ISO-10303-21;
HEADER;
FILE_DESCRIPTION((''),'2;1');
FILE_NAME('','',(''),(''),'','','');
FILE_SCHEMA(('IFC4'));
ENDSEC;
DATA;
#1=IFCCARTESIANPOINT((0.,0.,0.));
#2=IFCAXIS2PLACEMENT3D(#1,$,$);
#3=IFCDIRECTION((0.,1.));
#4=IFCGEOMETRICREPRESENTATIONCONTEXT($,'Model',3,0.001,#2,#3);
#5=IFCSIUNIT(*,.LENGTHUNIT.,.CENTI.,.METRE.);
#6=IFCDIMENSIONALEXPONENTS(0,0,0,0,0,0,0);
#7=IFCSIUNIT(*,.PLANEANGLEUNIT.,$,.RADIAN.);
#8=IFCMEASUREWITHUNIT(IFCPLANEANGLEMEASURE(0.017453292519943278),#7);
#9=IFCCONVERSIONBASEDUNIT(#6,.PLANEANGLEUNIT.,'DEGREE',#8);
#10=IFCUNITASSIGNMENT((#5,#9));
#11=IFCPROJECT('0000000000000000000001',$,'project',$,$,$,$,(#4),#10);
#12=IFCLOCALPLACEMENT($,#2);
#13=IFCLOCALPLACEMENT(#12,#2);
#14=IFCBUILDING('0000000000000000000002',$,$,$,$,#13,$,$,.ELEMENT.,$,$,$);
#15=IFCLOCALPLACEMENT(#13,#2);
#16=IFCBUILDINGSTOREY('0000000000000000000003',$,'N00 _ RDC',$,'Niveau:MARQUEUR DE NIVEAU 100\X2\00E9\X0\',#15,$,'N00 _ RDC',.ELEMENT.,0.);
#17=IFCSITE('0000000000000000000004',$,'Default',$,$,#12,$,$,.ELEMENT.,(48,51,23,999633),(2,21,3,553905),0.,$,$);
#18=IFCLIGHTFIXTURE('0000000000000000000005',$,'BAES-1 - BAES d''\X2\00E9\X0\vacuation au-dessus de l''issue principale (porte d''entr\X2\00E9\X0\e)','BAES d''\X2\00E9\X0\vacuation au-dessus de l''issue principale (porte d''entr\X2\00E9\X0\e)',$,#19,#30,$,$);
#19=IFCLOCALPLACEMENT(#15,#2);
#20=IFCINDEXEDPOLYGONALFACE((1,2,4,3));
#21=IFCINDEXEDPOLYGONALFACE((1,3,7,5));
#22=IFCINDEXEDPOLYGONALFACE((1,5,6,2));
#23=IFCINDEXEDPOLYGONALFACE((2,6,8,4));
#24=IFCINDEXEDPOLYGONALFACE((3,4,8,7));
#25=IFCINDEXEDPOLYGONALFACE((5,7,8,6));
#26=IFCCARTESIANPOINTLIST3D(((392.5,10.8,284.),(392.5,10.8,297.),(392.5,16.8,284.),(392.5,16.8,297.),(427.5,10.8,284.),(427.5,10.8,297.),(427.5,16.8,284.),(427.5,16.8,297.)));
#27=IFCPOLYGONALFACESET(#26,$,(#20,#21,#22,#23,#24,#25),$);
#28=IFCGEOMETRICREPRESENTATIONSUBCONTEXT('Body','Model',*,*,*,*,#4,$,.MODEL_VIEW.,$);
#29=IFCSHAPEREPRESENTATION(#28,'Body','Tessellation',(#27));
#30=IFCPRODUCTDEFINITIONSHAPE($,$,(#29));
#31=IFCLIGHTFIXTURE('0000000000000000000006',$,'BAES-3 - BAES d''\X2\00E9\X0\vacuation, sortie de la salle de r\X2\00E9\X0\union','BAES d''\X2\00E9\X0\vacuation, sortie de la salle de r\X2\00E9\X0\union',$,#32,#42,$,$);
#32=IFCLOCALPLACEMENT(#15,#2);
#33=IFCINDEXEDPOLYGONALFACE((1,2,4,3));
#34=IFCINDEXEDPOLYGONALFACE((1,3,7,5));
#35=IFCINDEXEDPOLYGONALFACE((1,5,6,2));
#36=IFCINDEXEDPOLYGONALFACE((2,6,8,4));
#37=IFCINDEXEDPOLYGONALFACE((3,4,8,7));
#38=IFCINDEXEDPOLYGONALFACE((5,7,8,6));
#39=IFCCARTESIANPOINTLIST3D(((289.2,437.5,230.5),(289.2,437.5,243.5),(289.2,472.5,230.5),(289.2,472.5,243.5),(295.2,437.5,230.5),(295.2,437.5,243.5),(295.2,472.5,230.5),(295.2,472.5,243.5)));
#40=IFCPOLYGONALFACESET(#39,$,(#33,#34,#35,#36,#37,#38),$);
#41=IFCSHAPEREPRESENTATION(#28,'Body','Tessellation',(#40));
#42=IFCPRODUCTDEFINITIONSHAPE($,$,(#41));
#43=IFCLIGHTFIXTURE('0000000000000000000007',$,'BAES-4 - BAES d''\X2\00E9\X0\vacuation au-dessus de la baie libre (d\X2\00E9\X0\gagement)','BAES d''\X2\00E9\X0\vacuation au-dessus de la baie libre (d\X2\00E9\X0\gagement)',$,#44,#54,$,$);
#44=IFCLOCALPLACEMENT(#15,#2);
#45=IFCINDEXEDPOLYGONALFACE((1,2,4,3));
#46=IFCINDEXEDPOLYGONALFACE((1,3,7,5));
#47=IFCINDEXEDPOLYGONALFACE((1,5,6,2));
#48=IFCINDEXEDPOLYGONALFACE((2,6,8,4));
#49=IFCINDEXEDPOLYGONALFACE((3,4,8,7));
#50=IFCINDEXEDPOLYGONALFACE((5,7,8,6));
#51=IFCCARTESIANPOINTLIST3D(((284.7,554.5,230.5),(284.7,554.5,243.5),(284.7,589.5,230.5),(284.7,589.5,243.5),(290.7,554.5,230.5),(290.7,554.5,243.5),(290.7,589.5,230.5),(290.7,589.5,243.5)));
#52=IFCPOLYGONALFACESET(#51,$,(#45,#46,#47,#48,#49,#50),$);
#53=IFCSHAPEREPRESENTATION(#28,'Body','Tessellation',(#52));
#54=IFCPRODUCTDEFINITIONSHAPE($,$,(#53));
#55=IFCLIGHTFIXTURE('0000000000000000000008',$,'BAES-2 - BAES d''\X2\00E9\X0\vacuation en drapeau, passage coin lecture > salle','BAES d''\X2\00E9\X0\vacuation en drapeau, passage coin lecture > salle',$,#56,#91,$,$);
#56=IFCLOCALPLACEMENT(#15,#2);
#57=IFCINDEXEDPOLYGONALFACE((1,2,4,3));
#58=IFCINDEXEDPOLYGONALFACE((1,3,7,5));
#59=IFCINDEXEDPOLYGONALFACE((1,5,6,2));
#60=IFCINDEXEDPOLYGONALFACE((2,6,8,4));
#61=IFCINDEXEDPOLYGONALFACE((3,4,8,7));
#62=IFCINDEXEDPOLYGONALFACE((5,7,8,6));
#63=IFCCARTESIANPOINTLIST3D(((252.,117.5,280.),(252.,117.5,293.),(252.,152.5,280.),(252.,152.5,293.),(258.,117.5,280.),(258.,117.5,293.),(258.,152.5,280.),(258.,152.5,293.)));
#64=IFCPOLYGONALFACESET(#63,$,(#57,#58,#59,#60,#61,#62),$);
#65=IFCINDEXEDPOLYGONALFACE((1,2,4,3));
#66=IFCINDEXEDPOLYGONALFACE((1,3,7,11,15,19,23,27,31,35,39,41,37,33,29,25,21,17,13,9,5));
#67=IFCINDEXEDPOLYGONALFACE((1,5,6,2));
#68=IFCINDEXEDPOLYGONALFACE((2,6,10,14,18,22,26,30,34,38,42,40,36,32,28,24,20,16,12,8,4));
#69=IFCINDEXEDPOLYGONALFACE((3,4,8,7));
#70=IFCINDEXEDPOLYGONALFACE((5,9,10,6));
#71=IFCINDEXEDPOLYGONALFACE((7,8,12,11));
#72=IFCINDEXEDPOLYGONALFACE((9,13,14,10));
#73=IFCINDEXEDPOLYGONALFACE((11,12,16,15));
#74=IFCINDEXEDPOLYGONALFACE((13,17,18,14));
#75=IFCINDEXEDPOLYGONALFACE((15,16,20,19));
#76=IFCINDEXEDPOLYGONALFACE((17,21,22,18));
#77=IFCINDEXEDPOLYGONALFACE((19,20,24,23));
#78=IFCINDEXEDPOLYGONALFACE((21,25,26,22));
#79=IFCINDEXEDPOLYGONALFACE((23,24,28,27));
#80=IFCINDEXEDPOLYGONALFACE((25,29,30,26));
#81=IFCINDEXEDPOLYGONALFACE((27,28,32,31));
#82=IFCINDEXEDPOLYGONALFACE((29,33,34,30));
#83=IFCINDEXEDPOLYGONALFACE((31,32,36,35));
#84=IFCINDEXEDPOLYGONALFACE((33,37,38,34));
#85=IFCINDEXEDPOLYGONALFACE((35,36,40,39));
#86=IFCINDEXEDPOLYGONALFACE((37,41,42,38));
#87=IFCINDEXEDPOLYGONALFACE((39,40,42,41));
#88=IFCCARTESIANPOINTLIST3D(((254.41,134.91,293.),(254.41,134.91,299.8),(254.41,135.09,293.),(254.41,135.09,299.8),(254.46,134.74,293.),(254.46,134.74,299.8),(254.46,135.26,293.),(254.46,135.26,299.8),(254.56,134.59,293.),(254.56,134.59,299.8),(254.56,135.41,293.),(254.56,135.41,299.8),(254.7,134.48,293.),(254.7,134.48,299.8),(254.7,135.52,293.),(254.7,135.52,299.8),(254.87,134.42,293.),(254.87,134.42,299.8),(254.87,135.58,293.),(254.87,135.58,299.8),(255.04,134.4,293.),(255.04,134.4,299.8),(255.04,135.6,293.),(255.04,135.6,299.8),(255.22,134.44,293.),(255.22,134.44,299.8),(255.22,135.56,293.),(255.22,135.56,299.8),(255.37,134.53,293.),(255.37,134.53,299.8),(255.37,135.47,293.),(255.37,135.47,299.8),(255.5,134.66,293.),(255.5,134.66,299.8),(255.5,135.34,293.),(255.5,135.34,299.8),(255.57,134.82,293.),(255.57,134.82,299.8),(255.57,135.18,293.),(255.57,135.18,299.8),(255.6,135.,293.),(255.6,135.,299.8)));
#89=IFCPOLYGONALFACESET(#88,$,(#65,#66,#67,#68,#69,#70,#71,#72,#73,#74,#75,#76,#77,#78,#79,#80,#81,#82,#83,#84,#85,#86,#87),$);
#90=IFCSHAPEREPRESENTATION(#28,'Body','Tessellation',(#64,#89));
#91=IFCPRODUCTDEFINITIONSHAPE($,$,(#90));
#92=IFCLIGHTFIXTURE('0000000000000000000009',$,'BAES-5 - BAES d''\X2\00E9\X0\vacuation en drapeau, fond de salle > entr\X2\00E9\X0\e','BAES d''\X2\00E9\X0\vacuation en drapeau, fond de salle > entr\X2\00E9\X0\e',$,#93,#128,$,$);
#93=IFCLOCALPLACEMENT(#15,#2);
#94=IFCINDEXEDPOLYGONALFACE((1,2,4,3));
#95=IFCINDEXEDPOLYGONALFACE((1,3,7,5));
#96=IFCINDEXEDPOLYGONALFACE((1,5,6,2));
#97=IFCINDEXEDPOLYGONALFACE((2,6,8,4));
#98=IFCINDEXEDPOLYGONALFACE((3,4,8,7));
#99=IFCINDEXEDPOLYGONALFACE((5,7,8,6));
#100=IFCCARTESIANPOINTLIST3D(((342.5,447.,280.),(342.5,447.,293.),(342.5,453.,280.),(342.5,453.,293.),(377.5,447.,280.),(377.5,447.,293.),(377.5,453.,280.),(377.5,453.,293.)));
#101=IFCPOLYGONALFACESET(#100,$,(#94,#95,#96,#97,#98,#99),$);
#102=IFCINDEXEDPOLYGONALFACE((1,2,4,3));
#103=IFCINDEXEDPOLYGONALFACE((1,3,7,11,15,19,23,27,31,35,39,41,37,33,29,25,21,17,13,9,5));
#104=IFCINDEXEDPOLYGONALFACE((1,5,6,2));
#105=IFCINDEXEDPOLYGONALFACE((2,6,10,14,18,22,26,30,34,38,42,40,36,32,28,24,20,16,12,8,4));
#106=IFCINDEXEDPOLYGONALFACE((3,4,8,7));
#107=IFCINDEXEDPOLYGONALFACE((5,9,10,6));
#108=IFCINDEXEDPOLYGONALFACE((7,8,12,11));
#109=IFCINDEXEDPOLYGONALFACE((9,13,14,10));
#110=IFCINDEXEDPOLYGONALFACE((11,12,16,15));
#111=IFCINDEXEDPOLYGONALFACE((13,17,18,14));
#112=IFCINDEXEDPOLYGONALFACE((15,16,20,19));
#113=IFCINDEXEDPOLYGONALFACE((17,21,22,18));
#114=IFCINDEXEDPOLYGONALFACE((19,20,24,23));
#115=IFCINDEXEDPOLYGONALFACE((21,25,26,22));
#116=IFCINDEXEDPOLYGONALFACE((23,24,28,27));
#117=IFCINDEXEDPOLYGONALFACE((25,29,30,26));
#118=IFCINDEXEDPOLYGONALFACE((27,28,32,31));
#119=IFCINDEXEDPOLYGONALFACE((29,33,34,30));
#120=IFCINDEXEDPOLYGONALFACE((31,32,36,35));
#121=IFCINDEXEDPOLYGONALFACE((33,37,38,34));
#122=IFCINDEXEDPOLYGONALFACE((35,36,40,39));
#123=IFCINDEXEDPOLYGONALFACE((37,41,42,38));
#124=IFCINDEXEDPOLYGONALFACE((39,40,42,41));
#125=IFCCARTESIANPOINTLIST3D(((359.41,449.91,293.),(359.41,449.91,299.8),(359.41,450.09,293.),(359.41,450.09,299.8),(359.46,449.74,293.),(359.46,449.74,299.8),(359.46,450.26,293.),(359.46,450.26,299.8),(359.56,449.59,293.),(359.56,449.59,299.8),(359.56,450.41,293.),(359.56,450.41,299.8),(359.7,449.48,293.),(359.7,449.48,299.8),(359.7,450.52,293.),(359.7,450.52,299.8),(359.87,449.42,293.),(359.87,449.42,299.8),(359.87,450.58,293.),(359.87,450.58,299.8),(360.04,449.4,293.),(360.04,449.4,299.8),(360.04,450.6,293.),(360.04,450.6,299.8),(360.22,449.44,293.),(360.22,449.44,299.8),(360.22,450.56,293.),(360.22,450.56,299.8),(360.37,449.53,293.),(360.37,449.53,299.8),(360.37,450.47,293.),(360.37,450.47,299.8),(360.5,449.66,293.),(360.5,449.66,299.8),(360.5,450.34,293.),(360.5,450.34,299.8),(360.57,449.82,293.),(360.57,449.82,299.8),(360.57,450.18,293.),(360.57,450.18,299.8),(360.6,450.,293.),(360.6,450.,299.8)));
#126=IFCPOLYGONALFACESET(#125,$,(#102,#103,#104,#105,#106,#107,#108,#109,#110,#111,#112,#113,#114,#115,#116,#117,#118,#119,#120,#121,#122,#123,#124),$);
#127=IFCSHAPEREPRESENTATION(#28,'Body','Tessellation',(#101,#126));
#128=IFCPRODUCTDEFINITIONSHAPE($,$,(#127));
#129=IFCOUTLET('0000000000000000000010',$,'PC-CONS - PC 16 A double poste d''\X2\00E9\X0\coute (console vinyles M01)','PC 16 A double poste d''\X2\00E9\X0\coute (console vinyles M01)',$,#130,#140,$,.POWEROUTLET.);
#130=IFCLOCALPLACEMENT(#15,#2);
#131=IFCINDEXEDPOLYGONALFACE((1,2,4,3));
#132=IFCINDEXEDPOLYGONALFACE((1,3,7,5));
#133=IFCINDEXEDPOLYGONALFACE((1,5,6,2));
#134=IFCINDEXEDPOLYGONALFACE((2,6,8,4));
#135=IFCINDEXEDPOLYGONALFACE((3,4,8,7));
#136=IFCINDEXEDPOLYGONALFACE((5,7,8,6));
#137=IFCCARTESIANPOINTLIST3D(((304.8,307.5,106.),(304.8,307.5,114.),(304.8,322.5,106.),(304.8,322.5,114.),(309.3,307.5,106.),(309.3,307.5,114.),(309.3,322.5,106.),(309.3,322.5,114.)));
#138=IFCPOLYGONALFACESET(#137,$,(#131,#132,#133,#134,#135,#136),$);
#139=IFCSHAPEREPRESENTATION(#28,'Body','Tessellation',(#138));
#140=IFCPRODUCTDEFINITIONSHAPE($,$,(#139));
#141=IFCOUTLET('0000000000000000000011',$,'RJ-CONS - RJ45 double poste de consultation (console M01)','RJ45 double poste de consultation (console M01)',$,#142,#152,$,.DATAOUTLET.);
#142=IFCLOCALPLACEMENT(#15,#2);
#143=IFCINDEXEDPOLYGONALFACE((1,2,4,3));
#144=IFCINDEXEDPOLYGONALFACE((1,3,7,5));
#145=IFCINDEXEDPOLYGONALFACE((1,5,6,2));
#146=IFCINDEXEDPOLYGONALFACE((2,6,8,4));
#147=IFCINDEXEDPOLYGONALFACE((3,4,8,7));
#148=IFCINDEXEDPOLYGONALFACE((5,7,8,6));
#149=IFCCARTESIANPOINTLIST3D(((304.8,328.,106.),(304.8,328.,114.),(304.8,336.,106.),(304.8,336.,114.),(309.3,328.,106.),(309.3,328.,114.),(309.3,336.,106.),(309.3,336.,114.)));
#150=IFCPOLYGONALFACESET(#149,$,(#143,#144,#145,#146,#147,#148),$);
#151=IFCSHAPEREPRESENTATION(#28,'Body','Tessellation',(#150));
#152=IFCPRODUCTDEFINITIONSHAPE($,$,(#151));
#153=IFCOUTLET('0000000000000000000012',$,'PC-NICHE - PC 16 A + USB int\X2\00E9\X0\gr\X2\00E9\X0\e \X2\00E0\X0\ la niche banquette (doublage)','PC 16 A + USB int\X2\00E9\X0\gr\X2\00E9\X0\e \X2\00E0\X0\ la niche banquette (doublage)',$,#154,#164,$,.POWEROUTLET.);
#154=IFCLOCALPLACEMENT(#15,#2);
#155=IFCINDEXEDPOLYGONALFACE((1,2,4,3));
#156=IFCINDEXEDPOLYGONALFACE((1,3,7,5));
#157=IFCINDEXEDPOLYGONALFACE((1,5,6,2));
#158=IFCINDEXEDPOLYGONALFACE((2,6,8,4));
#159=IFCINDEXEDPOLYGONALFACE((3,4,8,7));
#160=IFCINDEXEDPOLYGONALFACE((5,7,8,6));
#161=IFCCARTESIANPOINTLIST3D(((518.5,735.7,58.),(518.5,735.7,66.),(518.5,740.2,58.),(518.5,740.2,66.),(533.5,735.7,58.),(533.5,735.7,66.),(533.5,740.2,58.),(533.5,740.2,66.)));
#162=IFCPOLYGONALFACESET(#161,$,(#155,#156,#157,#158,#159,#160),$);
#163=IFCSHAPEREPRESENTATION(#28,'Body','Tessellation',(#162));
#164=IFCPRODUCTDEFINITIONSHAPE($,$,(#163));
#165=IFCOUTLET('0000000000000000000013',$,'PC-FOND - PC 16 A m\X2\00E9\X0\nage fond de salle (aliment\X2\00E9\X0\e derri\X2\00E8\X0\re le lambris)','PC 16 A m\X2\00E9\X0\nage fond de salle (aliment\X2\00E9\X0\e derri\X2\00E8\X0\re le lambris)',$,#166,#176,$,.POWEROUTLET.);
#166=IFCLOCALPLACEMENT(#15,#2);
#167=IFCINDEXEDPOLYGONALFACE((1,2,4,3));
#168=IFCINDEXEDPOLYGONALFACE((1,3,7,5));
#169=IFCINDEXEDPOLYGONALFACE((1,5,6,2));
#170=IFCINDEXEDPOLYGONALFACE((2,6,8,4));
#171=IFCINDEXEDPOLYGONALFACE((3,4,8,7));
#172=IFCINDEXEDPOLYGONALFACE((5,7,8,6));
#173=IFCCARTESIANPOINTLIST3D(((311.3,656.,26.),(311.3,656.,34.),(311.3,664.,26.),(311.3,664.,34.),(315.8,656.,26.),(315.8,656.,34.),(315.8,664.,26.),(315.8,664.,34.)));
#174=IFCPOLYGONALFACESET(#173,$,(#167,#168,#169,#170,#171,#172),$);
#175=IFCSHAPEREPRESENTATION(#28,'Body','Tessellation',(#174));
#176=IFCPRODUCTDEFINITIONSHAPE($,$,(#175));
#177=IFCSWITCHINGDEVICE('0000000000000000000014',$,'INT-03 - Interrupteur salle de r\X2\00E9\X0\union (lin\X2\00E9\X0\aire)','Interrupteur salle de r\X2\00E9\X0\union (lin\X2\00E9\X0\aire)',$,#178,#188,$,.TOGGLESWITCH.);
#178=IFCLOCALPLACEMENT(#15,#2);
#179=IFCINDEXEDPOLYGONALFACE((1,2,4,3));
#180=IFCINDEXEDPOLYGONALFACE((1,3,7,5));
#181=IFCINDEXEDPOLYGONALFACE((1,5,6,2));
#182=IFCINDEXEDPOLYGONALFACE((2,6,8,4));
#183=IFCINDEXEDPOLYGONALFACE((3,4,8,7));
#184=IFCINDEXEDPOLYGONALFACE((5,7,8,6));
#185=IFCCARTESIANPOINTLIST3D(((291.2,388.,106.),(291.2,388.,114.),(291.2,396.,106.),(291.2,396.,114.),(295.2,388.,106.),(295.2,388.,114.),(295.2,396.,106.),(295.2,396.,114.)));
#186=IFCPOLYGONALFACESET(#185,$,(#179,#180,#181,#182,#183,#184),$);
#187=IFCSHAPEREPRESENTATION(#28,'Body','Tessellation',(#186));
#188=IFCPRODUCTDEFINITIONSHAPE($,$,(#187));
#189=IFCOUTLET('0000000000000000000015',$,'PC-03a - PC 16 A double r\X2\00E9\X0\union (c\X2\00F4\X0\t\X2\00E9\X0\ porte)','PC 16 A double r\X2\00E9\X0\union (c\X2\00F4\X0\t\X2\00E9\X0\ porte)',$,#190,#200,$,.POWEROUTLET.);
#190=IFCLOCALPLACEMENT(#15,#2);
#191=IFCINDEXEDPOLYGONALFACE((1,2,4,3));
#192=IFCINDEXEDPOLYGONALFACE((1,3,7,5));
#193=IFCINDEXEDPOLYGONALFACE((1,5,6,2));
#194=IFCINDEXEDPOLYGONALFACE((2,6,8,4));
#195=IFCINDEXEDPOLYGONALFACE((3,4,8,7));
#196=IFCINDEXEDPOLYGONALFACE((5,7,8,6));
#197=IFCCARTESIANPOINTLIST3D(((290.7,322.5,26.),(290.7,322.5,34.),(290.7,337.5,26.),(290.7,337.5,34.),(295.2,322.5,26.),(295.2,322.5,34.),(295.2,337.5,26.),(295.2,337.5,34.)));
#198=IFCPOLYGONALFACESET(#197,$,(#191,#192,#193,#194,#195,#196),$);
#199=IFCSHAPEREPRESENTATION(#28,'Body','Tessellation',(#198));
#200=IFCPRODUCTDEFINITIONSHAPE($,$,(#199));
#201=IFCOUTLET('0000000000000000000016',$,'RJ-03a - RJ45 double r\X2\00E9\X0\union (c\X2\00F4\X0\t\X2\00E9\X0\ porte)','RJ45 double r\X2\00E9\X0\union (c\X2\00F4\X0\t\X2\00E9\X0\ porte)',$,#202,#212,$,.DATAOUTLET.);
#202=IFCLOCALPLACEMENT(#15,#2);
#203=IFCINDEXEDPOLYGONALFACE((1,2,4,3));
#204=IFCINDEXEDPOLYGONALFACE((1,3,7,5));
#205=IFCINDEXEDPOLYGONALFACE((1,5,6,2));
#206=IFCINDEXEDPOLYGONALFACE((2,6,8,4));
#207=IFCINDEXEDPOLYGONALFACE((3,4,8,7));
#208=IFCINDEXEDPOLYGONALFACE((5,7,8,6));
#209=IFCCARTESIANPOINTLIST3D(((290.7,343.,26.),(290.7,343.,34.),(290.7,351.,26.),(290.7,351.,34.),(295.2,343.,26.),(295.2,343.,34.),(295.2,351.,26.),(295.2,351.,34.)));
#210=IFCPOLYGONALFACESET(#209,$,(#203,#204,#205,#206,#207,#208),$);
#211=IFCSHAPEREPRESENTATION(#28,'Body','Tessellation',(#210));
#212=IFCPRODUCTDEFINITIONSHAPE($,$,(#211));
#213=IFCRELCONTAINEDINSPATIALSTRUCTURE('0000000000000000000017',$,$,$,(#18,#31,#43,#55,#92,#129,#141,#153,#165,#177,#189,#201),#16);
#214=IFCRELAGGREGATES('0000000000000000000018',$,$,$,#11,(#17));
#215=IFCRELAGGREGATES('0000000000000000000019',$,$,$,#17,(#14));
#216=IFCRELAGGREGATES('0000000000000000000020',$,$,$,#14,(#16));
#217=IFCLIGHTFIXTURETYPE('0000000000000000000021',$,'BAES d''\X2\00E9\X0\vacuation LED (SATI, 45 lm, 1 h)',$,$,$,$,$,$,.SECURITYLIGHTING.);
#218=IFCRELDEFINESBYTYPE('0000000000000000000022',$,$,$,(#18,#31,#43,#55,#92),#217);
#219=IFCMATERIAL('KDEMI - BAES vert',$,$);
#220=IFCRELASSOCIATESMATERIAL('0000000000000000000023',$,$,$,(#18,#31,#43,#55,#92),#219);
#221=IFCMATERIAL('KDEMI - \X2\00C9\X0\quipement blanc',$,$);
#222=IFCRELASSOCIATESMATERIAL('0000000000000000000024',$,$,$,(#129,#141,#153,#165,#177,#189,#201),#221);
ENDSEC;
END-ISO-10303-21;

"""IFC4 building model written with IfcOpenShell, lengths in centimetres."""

from ifc_helpers import new_model, entity, si_unit, converted_unit, direction, frame, frame_2d, origin, origin_with_axes, place, context, subcontext, project, spatial, rectangle, circle, extrude, material, type_object, element, save


model = new_model("IFC4")

# Units and contexts
model_context = context("Model", 3, precision=0.001, world=origin(), true_north=direction((0.0, 1.0)))
body_context = subcontext(model_context, "Body", "Model", "MODEL_VIEW")
ifc_project = project(units=[si_unit("LENGTHUNIT", "METRE", prefix="CENTI"), converted_unit("PLANEANGLEUNIT", "DEGREE", entity("IfcPlaneAngleMeasure", 0.017453292519943278), si_unit("PLANEANGLEUNIT", "RADIAN"), dimensions=[0, 0, 0, 0, 0, 0, 0])], contexts=[model_context])

# Site, building, storey
site_placement = place(None, origin())
site = spatial("IfcSite", under=ifc_project, at=site_placement, Name="Default", CompositionType="ELEMENT", RefLatitude=(48, 51, 23, 999633), RefLongitude=(2, 21, 3, 553905), RefElevation=0.0)
building_placement = place(site_placement, origin())
building = spatial("IfcBuilding", under=site, at=building_placement, CompositionType="ELEMENT")
storey_placement = place(building_placement, origin())
storey = spatial("IfcBuildingStorey", under=building, at=storey_placement, Name="N00 _ RDC", ObjectType="Niveau:MARQUEUR DE NIVEAU 100é", LongName="N00 _ RDC", CompositionType="ELEMENT", Elevation=0.0)

# Light fixtures
ifc_material_1 = material(Name="KDEMI - BAES vert")
light_fixture_type = type_object("IfcLightFixtureType", Name="BAES d'évacuation LED (SATI, 45 lm, 1 h)", PredefinedType="SECURITYLIGHTING")
light_fixture_1_placement = place(storey_placement, origin_with_axes())
element("IfcLightFixture", 1, at=light_fixture_1_placement, inside=storey, type_object=light_fixture_type, material=ifc_material_1, Name="BAES-1 - BAES d'évacuation au-dessus de l'issue principale (porte d'entrée)", Description="BAES d'évacuation au-dessus de l'issue principale (porte d'entrée)", context=body_context, shape_type="SweptSolid", body=[
    extrude(rectangle(XDim=35.0, YDim=6.0, at=frame_2d((410.0, 13.8))), frame((0.0, 0.0, 284.0)), (0.0, 0.0, 1.0), 13.0),
])
light_fixture_2_placement = place(storey_placement, origin_with_axes())
element("IfcLightFixture", 2, at=light_fixture_2_placement, inside=storey, type_object=light_fixture_type, material=ifc_material_1, Name="BAES-3 - BAES d'évacuation, sortie de la salle de réunion", Description="BAES d'évacuation, sortie de la salle de réunion", context=body_context, shape_type="SweptSolid", body=[
    extrude(rectangle(XDim=6.0, YDim=35.0, at=frame_2d((292.2, 455.0))), frame((0.0, 0.0, 230.5)), (0.0, 0.0, 1.0), 13.0),
])
light_fixture_3_placement = place(storey_placement, origin_with_axes())
element("IfcLightFixture", 3, at=light_fixture_3_placement, inside=storey, type_object=light_fixture_type, material=ifc_material_1, Name="BAES-4 - BAES d'évacuation au-dessus de la baie libre (dégagement)", Description="BAES d'évacuation au-dessus de la baie libre (dégagement)", context=body_context, shape_type="SweptSolid", body=[
    extrude(rectangle(XDim=6.0, YDim=35.0, at=frame_2d((287.7, 572.0))), frame((0.0, 0.0, 230.5)), (0.0, 0.0, 1.0), 13.0),
])
light_fixture_4_placement = place(storey_placement, origin_with_axes())
element("IfcLightFixture", 4, at=light_fixture_4_placement, inside=storey, type_object=light_fixture_type, material=ifc_material_1, Name="BAES-2 - BAES d'évacuation en drapeau, passage coin lecture > salle", Description="BAES d'évacuation en drapeau, passage coin lecture > salle", context=body_context, shape_type="SweptSolid", body=[
    extrude(rectangle(XDim=6.0, YDim=35.0, at=frame_2d((255.0, 135.0))), frame((0.0, 0.0, 280.0)), (0.0, 0.0, 1.0), 13.0),
    extrude(circle(Radius=0.6, at=frame_2d((255.0, 135.0))), frame((0.0, 0.0, 293.0)), (0.0, 0.0, 1.0), 6.8),
])
light_fixture_5_placement = place(storey_placement, origin_with_axes())
element("IfcLightFixture", 5, at=light_fixture_5_placement, inside=storey, type_object=light_fixture_type, material=ifc_material_1, Name="BAES-5 - BAES d'évacuation en drapeau, fond de salle > entrée", Description="BAES d'évacuation en drapeau, fond de salle > entrée", context=body_context, shape_type="SweptSolid", body=[
    extrude(rectangle(XDim=35.0, YDim=6.0, at=frame_2d((360.0, 450.0))), frame((0.0, 0.0, 280.0)), (0.0, 0.0, 1.0), 13.0),
    extrude(circle(Radius=0.6, at=frame_2d((360.0, 450.0))), frame((0.0, 0.0, 293.0)), (0.0, 0.0, 1.0), 6.8),
])

# Outlets
ifc_material_2 = material(Name="KDEMI - Équipement blanc")
outlet_1_placement = place(storey_placement, origin_with_axes())
element("IfcOutlet", 6, at=outlet_1_placement, inside=storey, material=ifc_material_2, Name="PC-CONS - PC 16 A double poste d'écoute (console vinyles M01)", Description="PC 16 A double poste d'écoute (console vinyles M01)", PredefinedType="POWEROUTLET", context=body_context, shape_type="SweptSolid", body=[
    extrude(rectangle(XDim=4.5, YDim=15.0, at=frame_2d((307.05, 315.0))), frame((0.0, 0.0, 106.0)), (0.0, 0.0, 1.0), 8.0),
])
outlet_2_placement = place(storey_placement, origin_with_axes())
element("IfcOutlet", 7, at=outlet_2_placement, inside=storey, material=ifc_material_2, Name="RJ-CONS - RJ45 double poste de consultation (console M01)", Description="RJ45 double poste de consultation (console M01)", PredefinedType="DATAOUTLET", context=body_context, shape_type="SweptSolid", body=[
    extrude(rectangle(XDim=4.5, YDim=8.0, at=frame_2d((307.05, 332.0))), frame((0.0, 0.0, 106.0)), (0.0, 0.0, 1.0), 8.0),
])
outlet_3_placement = place(storey_placement, origin_with_axes())
element("IfcOutlet", 8, at=outlet_3_placement, inside=storey, material=ifc_material_2, Name="PC-NICHE - PC 16 A + USB intégrée à la niche banquette (doublage)", Description="PC 16 A + USB intégrée à la niche banquette (doublage)", PredefinedType="POWEROUTLET", context=body_context, shape_type="SweptSolid", body=[
    extrude(rectangle(XDim=15.0, YDim=4.5, at=frame_2d((526.0, 737.95))), frame((0.0, 0.0, 58.0)), (0.0, 0.0, 1.0), 8.0),
])
outlet_4_placement = place(storey_placement, origin_with_axes())
element("IfcOutlet", 9, at=outlet_4_placement, inside=storey, material=ifc_material_2, Name="PC-FOND - PC 16 A ménage fond de salle (alimentée derrière le lambris)", Description="PC 16 A ménage fond de salle (alimentée derrière le lambris)", PredefinedType="POWEROUTLET", context=body_context, shape_type="SweptSolid", body=[
    extrude(rectangle(XDim=4.5, YDim=8.0, at=frame_2d((313.55, 660.0))), frame((0.0, 0.0, 26.0)), (0.0, 0.0, 1.0), 8.0),
])

# Switching device
switching_device_1_placement = place(storey_placement, origin_with_axes())
element("IfcSwitchingDevice", 10, at=switching_device_1_placement, inside=storey, material=ifc_material_2, Name="INT-03 - Interrupteur salle de réunion (linéaire)", Description="Interrupteur salle de réunion (linéaire)", PredefinedType="TOGGLESWITCH", context=body_context, shape_type="SweptSolid", body=[
    extrude(rectangle(XDim=4.0, YDim=8.0, at=frame_2d((293.2, 392.0))), frame((0.0, 0.0, 106.0)), (0.0, 0.0, 1.0), 8.0),
])

# Outlets
outlet_5_placement = place(storey_placement, origin_with_axes())
element("IfcOutlet", 11, at=outlet_5_placement, inside=storey, material=ifc_material_2, Name="PC-03a - PC 16 A double réunion (côté porte)", Description="PC 16 A double réunion (côté porte)", PredefinedType="POWEROUTLET", context=body_context, shape_type="SweptSolid", body=[
    extrude(rectangle(XDim=4.5, YDim=15.0, at=frame_2d((292.95, 330.0))), frame((0.0, 0.0, 26.0)), (0.0, 0.0, 1.0), 8.0),
])
outlet_6_placement = place(storey_placement, origin_with_axes())
element("IfcOutlet", 12, at=outlet_6_placement, inside=storey, material=ifc_material_2, Name="RJ-03a - RJ45 double réunion (côté porte)", Description="RJ45 double réunion (côté porte)", PredefinedType="DATAOUTLET", context=body_context, shape_type="SweptSolid", body=[
    extrude(rectangle(XDim=4.5, YDim=8.0, at=frame_2d((292.95, 347.0))), frame((0.0, 0.0, 26.0)), (0.0, 0.0, 1.0), 8.0),
])

save(model, "model.ifc")
